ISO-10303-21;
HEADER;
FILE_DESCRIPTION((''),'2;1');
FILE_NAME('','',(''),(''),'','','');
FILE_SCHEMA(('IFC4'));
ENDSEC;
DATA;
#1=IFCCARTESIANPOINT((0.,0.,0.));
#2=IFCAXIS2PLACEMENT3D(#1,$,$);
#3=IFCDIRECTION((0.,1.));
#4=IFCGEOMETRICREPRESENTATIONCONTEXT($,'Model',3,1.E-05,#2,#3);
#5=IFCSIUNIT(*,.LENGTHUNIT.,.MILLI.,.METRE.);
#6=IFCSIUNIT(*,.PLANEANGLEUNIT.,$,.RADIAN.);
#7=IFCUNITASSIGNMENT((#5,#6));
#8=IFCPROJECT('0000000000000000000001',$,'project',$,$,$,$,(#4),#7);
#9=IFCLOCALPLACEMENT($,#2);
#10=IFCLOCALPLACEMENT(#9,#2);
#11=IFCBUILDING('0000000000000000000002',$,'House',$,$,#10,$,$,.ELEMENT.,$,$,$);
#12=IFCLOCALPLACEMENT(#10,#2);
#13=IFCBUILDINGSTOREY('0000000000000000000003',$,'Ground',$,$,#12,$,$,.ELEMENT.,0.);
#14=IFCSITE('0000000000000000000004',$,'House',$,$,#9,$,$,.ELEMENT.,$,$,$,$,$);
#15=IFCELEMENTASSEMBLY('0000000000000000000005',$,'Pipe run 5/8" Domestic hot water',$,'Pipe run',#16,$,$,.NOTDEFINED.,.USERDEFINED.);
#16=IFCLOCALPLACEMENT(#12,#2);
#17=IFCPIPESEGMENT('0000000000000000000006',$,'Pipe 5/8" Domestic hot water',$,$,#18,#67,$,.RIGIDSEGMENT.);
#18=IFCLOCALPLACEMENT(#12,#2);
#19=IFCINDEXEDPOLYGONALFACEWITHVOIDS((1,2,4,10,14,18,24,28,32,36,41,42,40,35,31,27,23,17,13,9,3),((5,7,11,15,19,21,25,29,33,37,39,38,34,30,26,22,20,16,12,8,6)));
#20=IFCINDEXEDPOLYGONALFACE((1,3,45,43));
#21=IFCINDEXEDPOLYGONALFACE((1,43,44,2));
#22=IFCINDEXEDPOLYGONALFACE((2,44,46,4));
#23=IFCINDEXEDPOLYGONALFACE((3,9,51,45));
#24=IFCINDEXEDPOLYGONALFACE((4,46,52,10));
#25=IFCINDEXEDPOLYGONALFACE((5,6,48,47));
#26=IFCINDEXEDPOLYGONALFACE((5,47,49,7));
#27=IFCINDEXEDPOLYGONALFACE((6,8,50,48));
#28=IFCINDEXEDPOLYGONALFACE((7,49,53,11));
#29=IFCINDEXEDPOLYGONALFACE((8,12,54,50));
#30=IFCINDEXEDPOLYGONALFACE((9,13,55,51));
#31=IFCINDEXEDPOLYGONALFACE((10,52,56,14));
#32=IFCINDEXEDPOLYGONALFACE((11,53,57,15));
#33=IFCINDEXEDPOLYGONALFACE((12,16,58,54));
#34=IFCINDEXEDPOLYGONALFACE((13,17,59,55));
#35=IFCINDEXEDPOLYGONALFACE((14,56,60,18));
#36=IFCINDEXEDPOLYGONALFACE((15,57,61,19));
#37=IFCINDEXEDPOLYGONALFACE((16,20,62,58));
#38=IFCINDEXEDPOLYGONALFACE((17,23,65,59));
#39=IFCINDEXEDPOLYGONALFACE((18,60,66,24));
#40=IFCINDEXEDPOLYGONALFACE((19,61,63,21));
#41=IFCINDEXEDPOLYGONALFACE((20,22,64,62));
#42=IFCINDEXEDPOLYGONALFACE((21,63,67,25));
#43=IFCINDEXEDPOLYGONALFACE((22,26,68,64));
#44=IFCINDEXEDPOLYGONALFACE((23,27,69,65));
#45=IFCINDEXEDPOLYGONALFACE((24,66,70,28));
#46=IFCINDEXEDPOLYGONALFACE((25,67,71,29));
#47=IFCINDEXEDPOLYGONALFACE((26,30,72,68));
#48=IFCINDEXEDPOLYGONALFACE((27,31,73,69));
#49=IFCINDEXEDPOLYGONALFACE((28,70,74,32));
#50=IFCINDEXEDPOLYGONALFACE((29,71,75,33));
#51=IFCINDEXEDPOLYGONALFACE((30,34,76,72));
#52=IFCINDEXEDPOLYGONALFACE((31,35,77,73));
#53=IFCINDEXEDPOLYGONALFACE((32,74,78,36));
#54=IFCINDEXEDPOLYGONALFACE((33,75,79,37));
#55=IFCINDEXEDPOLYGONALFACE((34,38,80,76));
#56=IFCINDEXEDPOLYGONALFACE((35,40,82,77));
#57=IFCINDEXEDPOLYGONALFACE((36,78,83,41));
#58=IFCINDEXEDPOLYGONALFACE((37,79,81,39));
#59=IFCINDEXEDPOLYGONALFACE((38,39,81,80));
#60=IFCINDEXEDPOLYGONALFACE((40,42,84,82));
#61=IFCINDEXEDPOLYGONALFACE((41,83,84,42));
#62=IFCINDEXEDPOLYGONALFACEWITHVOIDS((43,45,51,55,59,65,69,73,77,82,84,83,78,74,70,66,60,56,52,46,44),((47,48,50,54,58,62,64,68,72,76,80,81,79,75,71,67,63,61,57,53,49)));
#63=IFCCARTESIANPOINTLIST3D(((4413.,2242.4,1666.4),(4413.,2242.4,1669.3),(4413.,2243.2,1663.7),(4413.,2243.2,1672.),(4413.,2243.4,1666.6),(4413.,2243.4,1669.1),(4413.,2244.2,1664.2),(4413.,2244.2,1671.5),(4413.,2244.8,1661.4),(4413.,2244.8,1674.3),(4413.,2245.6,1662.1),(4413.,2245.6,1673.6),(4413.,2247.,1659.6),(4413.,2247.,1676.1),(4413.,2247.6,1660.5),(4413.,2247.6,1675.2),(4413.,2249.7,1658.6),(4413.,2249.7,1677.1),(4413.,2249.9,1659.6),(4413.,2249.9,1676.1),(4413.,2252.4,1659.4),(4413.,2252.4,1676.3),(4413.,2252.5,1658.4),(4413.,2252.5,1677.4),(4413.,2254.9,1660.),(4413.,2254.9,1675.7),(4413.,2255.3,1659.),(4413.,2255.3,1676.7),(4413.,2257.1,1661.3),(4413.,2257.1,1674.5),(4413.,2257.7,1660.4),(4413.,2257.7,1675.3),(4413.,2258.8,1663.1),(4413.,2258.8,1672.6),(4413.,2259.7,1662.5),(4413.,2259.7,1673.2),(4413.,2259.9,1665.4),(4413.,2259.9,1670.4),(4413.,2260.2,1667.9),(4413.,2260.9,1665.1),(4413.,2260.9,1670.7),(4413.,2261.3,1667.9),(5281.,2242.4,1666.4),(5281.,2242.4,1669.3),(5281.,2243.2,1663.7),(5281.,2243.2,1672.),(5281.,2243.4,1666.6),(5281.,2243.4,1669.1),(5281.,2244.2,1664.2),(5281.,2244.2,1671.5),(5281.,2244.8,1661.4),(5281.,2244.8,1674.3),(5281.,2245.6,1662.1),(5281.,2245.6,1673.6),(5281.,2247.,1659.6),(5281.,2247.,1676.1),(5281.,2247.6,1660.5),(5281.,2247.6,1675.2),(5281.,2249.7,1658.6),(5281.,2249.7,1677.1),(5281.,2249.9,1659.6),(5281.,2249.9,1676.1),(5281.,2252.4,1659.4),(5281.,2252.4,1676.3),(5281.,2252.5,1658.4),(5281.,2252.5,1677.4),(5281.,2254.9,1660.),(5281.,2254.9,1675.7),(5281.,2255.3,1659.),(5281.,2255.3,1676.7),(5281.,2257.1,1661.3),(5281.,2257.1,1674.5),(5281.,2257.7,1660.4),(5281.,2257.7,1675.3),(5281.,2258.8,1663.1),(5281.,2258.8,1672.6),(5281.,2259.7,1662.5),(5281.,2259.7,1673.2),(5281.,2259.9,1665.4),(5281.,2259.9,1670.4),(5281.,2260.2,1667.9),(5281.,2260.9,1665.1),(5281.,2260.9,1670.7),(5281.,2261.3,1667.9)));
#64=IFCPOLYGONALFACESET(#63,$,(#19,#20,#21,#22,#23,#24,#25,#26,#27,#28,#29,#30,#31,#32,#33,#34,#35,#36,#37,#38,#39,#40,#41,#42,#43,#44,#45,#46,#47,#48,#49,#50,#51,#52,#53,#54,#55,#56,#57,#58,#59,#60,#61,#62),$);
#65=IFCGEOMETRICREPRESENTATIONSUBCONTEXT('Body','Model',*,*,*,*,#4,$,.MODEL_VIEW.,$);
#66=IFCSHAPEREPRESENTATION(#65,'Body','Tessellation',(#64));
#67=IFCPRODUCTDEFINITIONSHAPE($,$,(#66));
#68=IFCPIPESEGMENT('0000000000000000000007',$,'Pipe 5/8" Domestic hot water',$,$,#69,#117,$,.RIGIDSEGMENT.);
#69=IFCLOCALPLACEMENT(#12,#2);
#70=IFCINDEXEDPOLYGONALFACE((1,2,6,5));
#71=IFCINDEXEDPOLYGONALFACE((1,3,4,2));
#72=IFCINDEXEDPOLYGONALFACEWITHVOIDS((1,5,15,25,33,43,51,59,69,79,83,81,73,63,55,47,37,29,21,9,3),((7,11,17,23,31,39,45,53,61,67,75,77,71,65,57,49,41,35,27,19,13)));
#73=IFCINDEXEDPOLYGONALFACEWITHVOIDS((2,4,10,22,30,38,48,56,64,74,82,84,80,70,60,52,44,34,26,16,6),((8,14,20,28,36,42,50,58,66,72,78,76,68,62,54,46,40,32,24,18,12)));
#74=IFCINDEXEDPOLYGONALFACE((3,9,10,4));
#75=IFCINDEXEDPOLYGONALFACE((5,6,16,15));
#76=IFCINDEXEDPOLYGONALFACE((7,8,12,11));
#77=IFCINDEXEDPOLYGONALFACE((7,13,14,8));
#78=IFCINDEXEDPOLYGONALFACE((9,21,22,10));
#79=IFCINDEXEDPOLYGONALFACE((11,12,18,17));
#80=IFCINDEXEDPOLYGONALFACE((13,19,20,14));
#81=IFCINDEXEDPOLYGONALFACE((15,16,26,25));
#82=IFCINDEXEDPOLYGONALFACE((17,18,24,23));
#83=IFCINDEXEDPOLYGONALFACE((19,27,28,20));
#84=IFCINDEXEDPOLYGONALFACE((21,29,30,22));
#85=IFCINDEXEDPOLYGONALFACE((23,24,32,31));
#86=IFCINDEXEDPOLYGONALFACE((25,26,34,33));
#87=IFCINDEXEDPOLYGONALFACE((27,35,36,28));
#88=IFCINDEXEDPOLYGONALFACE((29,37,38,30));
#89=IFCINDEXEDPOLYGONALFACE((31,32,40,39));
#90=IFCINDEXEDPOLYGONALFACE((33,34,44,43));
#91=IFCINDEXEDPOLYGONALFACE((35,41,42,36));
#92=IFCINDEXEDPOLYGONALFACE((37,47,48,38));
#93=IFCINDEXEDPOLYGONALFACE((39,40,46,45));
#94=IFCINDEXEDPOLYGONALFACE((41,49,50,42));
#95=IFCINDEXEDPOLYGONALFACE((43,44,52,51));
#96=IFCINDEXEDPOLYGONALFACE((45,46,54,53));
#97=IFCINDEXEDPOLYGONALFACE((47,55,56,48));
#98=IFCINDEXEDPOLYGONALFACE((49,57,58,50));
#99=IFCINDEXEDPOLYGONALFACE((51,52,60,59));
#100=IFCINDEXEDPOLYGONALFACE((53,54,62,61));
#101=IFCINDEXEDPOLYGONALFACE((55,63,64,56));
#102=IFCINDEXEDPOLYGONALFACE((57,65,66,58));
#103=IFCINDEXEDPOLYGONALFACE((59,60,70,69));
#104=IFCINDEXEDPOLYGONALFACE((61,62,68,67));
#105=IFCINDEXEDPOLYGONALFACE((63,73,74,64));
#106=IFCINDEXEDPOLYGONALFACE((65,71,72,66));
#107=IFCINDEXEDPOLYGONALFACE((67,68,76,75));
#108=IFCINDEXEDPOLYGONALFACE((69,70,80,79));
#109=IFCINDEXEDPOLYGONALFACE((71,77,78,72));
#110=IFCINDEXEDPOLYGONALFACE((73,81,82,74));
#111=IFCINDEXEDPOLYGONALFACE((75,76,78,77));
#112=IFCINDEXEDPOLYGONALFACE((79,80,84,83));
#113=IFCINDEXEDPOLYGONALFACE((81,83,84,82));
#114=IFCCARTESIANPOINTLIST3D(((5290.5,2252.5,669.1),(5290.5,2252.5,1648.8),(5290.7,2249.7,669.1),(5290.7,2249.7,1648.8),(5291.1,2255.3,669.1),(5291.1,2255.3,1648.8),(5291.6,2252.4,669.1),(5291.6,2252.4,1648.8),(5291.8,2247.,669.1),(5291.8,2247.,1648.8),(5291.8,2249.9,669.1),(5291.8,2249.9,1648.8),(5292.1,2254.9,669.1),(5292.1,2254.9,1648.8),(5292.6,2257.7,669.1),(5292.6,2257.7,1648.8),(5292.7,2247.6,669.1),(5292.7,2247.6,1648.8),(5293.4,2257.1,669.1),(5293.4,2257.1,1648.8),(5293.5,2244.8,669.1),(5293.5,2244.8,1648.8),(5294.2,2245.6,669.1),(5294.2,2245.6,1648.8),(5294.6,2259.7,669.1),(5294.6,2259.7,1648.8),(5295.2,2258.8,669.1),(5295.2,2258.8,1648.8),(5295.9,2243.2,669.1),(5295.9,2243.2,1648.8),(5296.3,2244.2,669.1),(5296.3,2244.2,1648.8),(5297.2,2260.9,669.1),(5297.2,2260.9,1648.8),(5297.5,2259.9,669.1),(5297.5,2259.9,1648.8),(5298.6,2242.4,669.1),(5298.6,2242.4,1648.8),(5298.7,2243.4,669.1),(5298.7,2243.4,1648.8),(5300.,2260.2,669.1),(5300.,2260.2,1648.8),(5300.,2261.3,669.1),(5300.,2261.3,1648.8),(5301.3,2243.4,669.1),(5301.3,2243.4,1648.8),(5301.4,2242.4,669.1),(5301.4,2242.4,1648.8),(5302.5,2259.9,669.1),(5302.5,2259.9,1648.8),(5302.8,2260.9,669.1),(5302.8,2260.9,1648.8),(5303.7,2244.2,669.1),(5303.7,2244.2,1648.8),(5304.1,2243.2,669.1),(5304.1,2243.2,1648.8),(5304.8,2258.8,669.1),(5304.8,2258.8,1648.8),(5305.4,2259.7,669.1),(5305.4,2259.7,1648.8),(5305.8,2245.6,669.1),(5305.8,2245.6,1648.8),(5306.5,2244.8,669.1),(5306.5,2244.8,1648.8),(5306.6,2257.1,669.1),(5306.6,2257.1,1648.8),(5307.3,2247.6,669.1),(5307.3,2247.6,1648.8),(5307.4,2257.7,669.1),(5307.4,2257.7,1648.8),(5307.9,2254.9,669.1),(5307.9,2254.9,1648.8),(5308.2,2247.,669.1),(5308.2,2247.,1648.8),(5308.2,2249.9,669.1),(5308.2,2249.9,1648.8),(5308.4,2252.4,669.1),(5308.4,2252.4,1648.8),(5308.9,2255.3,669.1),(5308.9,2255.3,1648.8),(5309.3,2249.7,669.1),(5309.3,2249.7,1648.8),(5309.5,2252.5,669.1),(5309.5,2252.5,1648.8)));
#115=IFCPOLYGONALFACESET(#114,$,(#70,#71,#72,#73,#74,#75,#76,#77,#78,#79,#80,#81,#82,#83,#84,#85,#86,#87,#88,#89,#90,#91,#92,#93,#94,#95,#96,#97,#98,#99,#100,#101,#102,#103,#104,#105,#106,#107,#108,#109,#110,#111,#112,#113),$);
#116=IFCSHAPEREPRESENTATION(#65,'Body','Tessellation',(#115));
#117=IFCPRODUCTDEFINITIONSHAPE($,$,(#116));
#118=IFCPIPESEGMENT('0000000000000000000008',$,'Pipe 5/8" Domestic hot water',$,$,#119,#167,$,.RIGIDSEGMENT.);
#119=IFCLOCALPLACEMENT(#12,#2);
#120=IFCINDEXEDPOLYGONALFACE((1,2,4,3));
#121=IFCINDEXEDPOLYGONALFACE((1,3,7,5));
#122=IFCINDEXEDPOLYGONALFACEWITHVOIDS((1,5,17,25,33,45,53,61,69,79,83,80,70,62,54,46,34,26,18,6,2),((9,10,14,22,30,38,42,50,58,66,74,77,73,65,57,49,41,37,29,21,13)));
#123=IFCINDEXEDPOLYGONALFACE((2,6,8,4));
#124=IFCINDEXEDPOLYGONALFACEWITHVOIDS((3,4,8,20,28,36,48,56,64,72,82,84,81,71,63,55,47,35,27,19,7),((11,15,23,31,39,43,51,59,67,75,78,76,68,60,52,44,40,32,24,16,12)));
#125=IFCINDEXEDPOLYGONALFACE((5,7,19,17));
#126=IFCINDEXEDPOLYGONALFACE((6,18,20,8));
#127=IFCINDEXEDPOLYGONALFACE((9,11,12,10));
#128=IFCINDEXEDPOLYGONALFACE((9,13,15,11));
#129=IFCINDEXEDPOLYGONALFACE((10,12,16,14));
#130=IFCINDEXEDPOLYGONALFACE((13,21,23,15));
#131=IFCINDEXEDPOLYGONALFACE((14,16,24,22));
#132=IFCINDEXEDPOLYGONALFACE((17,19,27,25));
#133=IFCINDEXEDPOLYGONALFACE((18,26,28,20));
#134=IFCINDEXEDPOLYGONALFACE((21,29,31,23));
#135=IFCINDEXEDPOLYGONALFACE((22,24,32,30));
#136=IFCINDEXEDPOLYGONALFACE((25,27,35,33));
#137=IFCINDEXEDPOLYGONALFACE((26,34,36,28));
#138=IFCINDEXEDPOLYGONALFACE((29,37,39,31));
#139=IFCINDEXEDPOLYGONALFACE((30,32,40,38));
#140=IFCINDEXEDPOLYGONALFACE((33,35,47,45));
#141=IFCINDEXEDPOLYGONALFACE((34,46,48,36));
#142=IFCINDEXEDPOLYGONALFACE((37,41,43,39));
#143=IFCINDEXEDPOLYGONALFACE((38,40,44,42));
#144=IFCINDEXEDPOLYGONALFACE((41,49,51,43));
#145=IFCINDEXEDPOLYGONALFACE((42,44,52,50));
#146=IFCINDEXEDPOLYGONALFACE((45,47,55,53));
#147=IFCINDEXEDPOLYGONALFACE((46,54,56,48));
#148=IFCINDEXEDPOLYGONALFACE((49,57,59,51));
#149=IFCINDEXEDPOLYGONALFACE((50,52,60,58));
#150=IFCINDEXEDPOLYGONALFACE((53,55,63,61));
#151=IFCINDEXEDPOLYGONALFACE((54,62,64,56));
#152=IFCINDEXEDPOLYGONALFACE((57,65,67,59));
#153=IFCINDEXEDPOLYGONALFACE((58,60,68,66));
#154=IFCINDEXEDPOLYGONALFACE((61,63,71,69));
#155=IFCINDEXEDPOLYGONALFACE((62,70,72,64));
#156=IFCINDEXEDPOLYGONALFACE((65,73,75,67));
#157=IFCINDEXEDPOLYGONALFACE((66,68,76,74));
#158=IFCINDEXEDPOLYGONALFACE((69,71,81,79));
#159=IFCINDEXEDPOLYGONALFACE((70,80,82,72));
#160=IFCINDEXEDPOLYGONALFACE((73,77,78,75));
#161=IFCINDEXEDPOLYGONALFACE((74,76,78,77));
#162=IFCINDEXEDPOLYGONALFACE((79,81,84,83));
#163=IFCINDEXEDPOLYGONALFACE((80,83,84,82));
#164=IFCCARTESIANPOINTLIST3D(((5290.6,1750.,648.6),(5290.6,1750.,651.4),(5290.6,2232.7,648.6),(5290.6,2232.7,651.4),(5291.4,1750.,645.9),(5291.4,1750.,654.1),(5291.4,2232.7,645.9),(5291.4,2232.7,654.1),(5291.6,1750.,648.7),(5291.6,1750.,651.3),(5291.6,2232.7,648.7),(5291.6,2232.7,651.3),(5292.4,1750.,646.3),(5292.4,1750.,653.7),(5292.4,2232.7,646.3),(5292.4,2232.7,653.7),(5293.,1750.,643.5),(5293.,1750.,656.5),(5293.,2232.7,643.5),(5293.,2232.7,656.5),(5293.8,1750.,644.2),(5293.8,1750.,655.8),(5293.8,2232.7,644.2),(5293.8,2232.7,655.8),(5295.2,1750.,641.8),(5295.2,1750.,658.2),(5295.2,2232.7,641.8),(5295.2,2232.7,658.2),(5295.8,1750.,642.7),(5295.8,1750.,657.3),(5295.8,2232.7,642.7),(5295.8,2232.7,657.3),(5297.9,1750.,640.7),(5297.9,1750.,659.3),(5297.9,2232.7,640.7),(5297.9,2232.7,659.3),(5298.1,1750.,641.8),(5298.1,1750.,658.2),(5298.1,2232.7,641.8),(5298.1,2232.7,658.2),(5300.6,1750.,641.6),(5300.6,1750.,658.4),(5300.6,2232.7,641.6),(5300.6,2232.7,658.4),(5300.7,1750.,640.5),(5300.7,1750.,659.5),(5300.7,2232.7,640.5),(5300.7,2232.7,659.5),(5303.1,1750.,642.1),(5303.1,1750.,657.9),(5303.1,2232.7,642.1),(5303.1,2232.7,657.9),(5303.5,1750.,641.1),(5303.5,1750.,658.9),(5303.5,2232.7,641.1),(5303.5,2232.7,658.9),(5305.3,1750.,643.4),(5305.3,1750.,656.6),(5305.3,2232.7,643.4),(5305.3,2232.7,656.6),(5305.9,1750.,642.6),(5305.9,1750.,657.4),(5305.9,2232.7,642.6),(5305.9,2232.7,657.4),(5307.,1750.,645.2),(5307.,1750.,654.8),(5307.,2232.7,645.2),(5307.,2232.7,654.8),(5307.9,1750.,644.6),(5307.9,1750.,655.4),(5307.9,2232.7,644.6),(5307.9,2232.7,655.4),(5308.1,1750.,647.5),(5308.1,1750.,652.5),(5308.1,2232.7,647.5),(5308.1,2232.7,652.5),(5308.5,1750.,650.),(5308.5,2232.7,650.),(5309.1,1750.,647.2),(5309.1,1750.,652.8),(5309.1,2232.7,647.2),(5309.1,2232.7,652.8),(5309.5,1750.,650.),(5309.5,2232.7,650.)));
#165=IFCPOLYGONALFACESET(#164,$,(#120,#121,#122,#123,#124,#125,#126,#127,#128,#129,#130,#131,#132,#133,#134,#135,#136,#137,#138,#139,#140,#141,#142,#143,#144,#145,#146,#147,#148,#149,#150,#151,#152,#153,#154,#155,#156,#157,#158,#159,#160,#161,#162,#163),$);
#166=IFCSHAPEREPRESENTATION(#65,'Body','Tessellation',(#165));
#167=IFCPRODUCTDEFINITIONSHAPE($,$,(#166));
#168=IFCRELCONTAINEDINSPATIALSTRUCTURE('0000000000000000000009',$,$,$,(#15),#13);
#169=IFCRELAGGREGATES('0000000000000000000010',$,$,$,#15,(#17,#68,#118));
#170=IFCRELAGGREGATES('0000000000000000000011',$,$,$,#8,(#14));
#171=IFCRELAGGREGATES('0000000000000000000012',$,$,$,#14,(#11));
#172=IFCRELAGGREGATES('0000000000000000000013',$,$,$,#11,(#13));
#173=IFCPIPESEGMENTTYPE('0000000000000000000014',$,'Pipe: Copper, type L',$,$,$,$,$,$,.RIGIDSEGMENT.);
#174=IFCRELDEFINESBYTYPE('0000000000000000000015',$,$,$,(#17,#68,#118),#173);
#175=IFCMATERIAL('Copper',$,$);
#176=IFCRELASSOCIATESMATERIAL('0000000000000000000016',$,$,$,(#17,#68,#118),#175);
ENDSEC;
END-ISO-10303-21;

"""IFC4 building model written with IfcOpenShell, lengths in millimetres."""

from ifc_helpers import new_model, si_unit, direction, frame, origin, origin_with_axes, origin_2d, place, context, subcontext, project, spatial, hollow_circle, extrude, material, type_object, element, aggregate, save


model = new_model("IFC4")

# Units and contexts
model_context = context("Model", 3, precision=1e-05, world=origin(), true_north=direction((0.0, 1.0)))
body_context = subcontext(model_context, "Body", "Model", "MODEL_VIEW")
ifc_project = project(units=[si_unit("LENGTHUNIT", "METRE", prefix="MILLI"), si_unit("PLANEANGLEUNIT", "RADIAN")], contexts=[model_context])

# Site, building, storey
site_placement = place(None, origin())
site = spatial("IfcSite", under=ifc_project, at=site_placement, Name="House", CompositionType="ELEMENT")
building_placement = place(site_placement, origin())
building = spatial("IfcBuilding", under=site, at=building_placement, Name="House", CompositionType="ELEMENT")
storey_placement = place(building_placement, origin())
storey = spatial("IfcBuildingStorey", under=building, at=storey_placement, Name="Ground", CompositionType="ELEMENT", Elevation=0.0)

# Element assembly, pipe segments
ifc_material = material(Name="Copper")
pipe_segment_type = type_object("IfcPipeSegmentType", Name="Pipe: Copper, type L", PredefinedType="RIGIDSEGMENT")
assembly_1_placement = place(storey_placement, origin_with_axes())
assembly_1 = element("IfcElementAssembly", 1, at=assembly_1_placement, inside=storey, Name="Pipe run 5/8\" Domestic hot water", ObjectType="Pipe run", AssemblyPlace="NOTDEFINED", PredefinedType="USERDEFINED")
pipe_segment_1_placement = place(storey_placement, origin_with_axes())
pipe_segment_1 = element("IfcPipeSegment", 2, at=pipe_segment_1_placement, type_object=pipe_segment_type, material=ifc_material, Name="Pipe 5/8\" Domestic hot water", PredefinedType="RIGIDSEGMENT", context=body_context, shape_type="SweptSolid", body=[
    extrude(hollow_circle(Radius=9.5, WallThickness=1.1, at=origin_2d()), frame((4413.0, 2251.8, 1667.9), z_axis=(1.0, 0.0, 0.0), x_axis=(0.0, 1.0, 0.0)), (0.0, 0.0, 1.0), 868.0),
])
pipe_segment_2_placement = place(storey_placement, origin_with_axes())
pipe_segment_2 = element("IfcPipeSegment", 3, at=pipe_segment_2_placement, type_object=pipe_segment_type, material=ifc_material, Name="Pipe 5/8\" Domestic hot water", PredefinedType="RIGIDSEGMENT", context=body_context, shape_type="SweptSolid", body=[
    extrude(hollow_circle(Radius=9.5, WallThickness=1.1, at=origin_2d()), frame((5300.0, 2251.8, 1648.8), z_axis=(0.0, 0.0, -1.0), x_axis=(0.0, 1.0, 0.0)), (0.0, 0.0, 1.0), 979.8),
])
pipe_segment_3_placement = place(storey_placement, origin_with_axes())
pipe_segment_3 = element("IfcPipeSegment", 4, at=pipe_segment_3_placement, type_object=pipe_segment_type, material=ifc_material, Name="Pipe 5/8\" Domestic hot water", PredefinedType="RIGIDSEGMENT", context=body_context, shape_type="SweptSolid", body=[
    extrude(hollow_circle(Radius=9.5, WallThickness=1.1, at=origin_2d()), frame((5300.0, 2232.7, 650.0), z_axis=(0.0, -1.0, 0.0), x_axis=(1.0, 0.0, 0.0)), (0.0, 0.0, 1.0), 482.7),
])

aggregate(assembly_1, [pipe_segment_1, pipe_segment_2, pipe_segment_3])

save(model, "model.ifc")
